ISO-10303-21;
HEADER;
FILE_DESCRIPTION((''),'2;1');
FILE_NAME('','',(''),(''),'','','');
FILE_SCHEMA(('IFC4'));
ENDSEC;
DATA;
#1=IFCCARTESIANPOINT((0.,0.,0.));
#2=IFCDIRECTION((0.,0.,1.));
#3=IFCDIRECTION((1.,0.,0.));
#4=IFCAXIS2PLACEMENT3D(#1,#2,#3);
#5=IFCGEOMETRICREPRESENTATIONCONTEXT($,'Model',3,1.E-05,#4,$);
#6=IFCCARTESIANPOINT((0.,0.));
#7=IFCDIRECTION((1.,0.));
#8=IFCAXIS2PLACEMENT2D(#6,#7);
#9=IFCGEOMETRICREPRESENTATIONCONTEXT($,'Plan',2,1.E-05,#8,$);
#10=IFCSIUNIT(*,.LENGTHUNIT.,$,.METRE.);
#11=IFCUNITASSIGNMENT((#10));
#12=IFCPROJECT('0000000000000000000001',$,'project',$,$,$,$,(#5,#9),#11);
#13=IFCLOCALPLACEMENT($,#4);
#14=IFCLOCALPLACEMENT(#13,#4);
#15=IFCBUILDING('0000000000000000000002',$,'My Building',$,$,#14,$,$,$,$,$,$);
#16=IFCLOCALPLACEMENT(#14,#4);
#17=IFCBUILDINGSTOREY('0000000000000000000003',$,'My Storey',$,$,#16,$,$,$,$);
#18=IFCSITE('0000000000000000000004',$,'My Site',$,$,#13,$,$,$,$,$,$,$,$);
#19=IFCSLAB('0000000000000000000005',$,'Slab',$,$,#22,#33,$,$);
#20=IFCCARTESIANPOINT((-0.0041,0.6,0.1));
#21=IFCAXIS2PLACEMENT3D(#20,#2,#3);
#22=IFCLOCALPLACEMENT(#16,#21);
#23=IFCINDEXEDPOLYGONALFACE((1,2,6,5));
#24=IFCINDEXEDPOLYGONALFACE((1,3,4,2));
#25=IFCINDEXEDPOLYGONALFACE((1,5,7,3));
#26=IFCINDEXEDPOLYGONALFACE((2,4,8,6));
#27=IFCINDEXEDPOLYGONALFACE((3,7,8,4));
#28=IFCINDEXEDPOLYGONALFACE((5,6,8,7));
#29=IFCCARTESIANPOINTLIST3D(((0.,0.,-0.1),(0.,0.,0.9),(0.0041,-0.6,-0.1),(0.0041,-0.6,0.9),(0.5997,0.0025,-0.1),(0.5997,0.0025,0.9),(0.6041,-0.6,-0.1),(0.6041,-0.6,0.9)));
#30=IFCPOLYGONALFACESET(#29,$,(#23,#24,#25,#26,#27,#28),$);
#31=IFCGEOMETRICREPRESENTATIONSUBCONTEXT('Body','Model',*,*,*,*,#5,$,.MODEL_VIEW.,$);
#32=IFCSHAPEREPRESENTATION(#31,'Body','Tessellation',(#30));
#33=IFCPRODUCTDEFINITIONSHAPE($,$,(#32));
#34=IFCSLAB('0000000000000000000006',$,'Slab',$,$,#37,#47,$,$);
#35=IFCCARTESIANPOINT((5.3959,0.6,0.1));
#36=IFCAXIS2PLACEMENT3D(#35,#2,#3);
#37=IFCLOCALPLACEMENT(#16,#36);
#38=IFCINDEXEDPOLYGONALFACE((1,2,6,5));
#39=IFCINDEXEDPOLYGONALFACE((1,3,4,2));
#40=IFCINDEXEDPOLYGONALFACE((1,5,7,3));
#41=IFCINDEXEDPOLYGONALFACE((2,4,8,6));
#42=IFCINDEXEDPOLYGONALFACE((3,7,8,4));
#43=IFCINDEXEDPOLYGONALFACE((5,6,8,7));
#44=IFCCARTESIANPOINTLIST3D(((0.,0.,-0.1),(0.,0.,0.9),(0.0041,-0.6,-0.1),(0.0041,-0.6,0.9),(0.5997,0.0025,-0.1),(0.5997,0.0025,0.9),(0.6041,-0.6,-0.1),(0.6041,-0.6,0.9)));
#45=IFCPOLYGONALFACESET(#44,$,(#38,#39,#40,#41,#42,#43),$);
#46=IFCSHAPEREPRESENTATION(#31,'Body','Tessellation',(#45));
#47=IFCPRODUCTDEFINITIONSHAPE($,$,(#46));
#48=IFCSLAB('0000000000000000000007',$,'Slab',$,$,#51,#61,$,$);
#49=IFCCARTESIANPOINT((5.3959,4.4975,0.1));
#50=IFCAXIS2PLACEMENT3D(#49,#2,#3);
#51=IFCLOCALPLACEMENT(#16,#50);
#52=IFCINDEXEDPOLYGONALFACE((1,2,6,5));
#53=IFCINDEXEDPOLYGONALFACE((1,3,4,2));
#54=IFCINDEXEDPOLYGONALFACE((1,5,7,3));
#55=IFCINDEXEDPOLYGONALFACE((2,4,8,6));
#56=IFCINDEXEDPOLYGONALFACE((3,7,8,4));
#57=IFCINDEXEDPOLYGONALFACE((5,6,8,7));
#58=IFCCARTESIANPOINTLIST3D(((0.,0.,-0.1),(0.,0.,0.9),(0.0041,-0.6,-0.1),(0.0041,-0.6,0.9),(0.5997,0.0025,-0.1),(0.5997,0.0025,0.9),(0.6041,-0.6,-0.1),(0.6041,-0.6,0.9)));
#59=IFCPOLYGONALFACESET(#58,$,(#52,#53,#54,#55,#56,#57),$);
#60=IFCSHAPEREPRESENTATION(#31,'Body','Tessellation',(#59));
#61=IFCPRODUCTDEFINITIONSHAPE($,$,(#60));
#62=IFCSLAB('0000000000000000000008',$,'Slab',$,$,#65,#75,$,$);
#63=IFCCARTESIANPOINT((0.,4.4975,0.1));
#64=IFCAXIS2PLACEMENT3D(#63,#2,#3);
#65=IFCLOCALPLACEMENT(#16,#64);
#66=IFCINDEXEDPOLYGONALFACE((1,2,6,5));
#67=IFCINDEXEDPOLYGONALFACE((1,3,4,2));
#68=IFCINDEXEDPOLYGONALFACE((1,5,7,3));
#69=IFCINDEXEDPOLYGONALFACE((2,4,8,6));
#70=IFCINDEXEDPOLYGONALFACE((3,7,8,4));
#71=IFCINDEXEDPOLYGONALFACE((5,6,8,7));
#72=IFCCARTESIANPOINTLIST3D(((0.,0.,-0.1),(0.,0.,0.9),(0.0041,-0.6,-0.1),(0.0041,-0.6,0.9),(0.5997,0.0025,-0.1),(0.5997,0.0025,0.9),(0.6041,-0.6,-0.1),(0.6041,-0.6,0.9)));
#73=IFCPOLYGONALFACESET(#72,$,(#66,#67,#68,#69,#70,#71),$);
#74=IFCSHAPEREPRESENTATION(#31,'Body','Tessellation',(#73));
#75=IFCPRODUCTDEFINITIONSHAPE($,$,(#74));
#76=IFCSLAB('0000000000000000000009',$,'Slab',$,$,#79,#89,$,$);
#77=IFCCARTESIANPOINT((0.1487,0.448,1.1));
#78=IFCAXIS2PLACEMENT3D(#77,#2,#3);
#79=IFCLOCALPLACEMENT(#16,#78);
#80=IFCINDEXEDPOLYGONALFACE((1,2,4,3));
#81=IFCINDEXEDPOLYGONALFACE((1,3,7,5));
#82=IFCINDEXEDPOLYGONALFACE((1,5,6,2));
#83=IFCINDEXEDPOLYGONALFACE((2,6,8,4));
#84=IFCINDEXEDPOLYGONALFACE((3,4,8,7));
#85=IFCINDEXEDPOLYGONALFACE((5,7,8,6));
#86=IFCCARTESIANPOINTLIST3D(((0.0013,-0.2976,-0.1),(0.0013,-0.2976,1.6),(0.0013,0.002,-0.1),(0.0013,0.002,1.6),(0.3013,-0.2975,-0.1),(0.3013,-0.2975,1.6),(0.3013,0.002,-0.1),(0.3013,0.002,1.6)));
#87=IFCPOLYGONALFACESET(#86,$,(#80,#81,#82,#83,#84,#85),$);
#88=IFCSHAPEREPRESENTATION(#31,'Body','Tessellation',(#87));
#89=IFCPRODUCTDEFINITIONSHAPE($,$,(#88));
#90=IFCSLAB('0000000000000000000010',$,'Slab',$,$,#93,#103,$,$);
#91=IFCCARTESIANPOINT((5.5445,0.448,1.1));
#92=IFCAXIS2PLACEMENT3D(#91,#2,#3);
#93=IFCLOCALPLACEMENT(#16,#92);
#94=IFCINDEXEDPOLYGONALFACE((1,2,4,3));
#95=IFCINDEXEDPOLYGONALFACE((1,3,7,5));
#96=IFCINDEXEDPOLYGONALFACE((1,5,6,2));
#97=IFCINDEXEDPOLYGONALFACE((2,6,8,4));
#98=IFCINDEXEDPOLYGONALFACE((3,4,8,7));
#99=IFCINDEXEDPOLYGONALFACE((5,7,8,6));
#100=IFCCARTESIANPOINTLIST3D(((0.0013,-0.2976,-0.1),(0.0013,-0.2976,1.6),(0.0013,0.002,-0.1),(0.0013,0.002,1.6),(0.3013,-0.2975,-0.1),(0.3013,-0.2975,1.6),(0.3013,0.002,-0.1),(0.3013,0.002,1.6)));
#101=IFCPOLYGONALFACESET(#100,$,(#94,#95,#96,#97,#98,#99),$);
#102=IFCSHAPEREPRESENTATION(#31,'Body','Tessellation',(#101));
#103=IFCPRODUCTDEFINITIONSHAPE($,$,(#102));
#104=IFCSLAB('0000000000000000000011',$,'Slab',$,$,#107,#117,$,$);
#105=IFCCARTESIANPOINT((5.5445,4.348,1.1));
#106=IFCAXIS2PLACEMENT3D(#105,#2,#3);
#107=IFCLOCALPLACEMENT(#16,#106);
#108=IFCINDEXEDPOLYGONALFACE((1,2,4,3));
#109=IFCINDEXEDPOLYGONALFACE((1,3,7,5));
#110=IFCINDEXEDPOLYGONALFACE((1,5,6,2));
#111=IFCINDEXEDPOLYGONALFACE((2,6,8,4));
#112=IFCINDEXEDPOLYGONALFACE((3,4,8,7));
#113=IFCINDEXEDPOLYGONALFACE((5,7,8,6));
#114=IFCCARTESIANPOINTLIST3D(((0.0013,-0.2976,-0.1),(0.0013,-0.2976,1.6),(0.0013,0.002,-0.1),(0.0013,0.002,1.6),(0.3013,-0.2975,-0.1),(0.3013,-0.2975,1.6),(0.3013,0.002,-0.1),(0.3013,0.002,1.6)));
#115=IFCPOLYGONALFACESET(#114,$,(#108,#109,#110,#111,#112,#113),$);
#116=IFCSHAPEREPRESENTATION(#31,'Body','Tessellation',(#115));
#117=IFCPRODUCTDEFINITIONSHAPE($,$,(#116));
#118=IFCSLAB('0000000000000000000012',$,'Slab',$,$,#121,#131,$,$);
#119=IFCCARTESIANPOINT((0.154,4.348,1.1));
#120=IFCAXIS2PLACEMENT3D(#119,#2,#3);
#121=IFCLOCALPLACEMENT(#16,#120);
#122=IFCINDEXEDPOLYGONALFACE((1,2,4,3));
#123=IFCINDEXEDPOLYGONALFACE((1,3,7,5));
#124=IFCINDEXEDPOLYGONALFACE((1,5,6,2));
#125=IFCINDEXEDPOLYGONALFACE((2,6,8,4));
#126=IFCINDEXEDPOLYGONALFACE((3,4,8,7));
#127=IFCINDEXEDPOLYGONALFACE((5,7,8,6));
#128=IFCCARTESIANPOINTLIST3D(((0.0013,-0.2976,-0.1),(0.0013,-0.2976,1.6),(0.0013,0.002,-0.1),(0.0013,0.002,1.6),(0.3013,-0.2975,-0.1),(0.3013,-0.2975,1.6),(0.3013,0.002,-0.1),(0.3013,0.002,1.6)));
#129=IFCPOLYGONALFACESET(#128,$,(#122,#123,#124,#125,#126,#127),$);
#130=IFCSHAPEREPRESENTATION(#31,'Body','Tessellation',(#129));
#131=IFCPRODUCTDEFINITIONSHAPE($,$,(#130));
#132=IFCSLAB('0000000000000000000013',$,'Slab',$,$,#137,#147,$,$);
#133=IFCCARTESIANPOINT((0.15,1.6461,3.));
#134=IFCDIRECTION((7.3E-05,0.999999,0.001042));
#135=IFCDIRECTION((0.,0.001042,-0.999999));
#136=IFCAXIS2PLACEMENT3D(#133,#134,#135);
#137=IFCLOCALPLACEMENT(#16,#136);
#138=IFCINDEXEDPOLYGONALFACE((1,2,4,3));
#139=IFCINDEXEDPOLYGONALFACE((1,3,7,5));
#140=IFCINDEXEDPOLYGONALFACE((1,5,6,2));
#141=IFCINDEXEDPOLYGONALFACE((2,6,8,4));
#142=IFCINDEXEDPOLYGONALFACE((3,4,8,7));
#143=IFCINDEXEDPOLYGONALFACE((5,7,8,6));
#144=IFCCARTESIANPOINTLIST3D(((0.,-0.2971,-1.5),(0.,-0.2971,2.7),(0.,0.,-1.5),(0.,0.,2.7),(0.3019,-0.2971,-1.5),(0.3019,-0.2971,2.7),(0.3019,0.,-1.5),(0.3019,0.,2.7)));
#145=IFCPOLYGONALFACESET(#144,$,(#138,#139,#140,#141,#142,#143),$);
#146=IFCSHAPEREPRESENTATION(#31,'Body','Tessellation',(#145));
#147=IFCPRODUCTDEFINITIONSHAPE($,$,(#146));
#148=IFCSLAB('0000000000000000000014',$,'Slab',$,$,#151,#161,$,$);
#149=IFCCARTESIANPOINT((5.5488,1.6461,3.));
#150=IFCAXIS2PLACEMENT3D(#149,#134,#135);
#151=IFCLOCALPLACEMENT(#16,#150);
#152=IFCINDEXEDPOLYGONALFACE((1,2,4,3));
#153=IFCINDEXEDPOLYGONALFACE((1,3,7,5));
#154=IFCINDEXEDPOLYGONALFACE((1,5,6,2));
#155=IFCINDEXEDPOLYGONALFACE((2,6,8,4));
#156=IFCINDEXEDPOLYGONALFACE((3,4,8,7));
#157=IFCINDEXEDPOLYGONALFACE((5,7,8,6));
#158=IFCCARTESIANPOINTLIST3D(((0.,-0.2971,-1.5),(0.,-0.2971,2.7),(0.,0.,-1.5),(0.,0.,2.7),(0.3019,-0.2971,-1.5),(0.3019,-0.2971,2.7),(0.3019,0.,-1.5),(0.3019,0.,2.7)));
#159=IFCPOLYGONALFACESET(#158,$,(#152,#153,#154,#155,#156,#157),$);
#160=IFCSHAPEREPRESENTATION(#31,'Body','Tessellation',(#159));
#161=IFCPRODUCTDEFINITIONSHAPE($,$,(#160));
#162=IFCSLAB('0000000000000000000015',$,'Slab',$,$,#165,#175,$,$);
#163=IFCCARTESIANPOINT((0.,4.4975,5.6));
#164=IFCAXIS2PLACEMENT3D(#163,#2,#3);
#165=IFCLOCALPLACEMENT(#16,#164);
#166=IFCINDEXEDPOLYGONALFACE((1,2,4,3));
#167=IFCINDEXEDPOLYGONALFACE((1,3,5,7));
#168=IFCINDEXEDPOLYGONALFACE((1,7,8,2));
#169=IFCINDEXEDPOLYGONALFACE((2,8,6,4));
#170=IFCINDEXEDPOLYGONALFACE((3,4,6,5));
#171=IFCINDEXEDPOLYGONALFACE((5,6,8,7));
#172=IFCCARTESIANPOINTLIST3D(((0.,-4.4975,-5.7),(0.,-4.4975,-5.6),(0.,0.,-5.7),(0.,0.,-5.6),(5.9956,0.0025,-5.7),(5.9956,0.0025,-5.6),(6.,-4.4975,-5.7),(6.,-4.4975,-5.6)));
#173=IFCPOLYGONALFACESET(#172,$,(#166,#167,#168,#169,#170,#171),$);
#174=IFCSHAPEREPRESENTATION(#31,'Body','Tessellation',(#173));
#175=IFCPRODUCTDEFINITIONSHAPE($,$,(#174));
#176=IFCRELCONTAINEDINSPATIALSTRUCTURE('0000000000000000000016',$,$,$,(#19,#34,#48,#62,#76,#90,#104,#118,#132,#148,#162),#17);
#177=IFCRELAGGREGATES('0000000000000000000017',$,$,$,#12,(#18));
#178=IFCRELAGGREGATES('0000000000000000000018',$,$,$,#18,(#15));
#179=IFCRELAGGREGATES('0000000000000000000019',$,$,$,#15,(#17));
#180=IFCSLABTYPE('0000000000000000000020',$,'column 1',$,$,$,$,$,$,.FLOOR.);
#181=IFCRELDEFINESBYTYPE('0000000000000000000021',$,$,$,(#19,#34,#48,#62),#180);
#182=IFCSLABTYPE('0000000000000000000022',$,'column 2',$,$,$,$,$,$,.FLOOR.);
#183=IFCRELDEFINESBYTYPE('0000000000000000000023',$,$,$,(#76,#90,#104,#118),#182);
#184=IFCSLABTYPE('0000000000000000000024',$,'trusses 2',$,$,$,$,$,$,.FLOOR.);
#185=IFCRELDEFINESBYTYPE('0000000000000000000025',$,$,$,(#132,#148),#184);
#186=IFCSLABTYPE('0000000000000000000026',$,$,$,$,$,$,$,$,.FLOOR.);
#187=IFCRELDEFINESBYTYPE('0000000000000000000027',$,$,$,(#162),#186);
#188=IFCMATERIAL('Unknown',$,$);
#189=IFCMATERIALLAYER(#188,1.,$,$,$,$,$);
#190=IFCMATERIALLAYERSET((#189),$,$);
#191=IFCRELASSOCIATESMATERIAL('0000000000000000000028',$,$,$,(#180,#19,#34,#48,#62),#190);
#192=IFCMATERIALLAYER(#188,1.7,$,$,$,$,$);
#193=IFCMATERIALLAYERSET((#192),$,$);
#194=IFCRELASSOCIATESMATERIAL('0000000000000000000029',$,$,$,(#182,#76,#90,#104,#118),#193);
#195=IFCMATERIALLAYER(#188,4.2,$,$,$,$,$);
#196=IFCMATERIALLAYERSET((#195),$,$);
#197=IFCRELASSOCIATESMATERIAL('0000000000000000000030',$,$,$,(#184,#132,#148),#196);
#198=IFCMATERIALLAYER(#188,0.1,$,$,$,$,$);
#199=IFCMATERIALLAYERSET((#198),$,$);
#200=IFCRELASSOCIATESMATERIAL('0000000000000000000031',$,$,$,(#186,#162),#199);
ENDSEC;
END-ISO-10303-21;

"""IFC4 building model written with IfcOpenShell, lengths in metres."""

from ifc_helpers import new_model, si_unit, frame, origin_with_axes, origin_2d_with_axis, place, context, subcontext, project, spatial, indexed_curve, outline, extrude, material, layer, layer_set, layer_usage, type_object, element, save


model = new_model("IFC4")

# Units and contexts
model_context = context("Model", 3, precision=1e-05, world=origin_with_axes())
plan_context = context("Plan", 2, precision=1e-05, world=origin_2d_with_axis())
body_context_1 = subcontext(model_context, "Body", "Model", "MODEL_VIEW")
ifc_project = project(units=[si_unit("LENGTHUNIT", "METRE")], contexts=[model_context, plan_context])

# Site, building, storey
site_placement = place(None, origin_with_axes())
site = spatial("IfcSite", under=ifc_project, at=site_placement, Name="My Site")
building_placement = place(site_placement, origin_with_axes())
building = spatial("IfcBuilding", under=site, at=building_placement, Name="My Building")
storey_placement = place(building_placement, origin_with_axes())
storey = spatial("IfcBuildingStorey", under=building, at=storey_placement, Name="My Storey")

# Slabs
ifc_material = material(Name="Unknown")
ifc_layer_1 = layer(ifc_material, 1.0)
ifc_layer_set_1 = layer_set([ifc_layer_1])
ifc_layer_usage_1 = layer_usage(ifc_layer_set_1, "AXIS3", "POSITIVE", -0.1)
slab_type_1 = type_object("IfcSlabType", Name="column 1", PredefinedType="FLOOR", material=ifc_layer_set_1)
slab_1_placement = place(storey_placement, frame((-0.0041, 0.6, 0.1), z_axis=(0.0, 0.0, 1.0), x_axis=(1.0, 0.0, 0.0)))
element("IfcSlab", 1, at=slab_1_placement, inside=storey, type_object=slab_type_1, material=ifc_layer_usage_1, Name="Slab", context=body_context_1, shape_type="SweptSolid", body=[
    extrude(outline(indexed_curve([(0.0, 0.0), (0.5997, 0.0025), (0.6041, -0.6), (0.0041, -0.6), (0.0, 0.0)])), frame((0.0, 0.0, -0.1), z_axis=(0.0, 0.0, 1.0), x_axis=(1.0, 0.0, 0.0)), (0.0, 0.0, 1.0), 1.0),
])
ifc_layer_usage_2 = layer_usage(ifc_layer_set_1, "AXIS3", "POSITIVE", -0.1)
slab_2_placement = place(storey_placement, frame((5.3959, 0.6, 0.1), z_axis=(0.0, 0.0, 1.0), x_axis=(1.0, 0.0, 0.0)))
element("IfcSlab", 2, at=slab_2_placement, inside=storey, type_object=slab_type_1, material=ifc_layer_usage_2, Name="Slab", context=body_context_1, shape_type="SweptSolid", body=[
    extrude(outline(indexed_curve([(0.0, 0.0), (0.5997, 0.0025), (0.6041, -0.6), (0.0041, -0.6), (0.0, 0.0)])), frame((0.0, 0.0, -0.1), z_axis=(0.0, 0.0, 1.0), x_axis=(1.0, 0.0, 0.0)), (0.0, 0.0, 1.0), 1.0),
])
ifc_layer_usage_3 = layer_usage(ifc_layer_set_1, "AXIS3", "POSITIVE", -0.1)
slab_3_placement = place(storey_placement, frame((5.3959, 4.4975, 0.1), z_axis=(0.0, 0.0, 1.0), x_axis=(1.0, 0.0, 0.0)))
element("IfcSlab", 3, at=slab_3_placement, inside=storey, type_object=slab_type_1, material=ifc_layer_usage_3, Name="Slab", context=body_context_1, shape_type="SweptSolid", body=[
    extrude(outline(indexed_curve([(0.0, 0.0), (0.5997, 0.0025), (0.6041, -0.6), (0.0041, -0.6), (0.0, 0.0)])), frame((0.0, 0.0, -0.1), z_axis=(0.0, 0.0, 1.0), x_axis=(1.0, 0.0, 0.0)), (0.0, 0.0, 1.0), 1.0),
])
ifc_layer_usage_4 = layer_usage(ifc_layer_set_1, "AXIS3", "POSITIVE", -0.1)
slab_4_placement = place(storey_placement, frame((0.0, 4.4975, 0.1), z_axis=(0.0, 0.0, 1.0), x_axis=(1.0, 0.0, 0.0)))
element("IfcSlab", 4, at=slab_4_placement, inside=storey, type_object=slab_type_1, material=ifc_layer_usage_4, Name="Slab", context=body_context_1, shape_type="SweptSolid", body=[
    extrude(outline(indexed_curve([(0.0, 0.0), (0.5997, 0.0025), (0.6041, -0.6), (0.0041, -0.6), (0.0, 0.0)])), frame((0.0, 0.0, -0.1), z_axis=(0.0, 0.0, 1.0), x_axis=(1.0, 0.0, 0.0)), (0.0, 0.0, 1.0), 1.0),
])
ifc_layer_2 = layer(ifc_material, 1.7)
ifc_layer_set_2 = layer_set([ifc_layer_2])
ifc_layer_usage_5 = layer_usage(ifc_layer_set_2, "AXIS3", "POSITIVE", -0.1)
slab_type_2 = type_object("IfcSlabType", Name="column 2", PredefinedType="FLOOR", material=ifc_layer_set_2)
slab_5_placement = place(storey_placement, frame((0.1487, 0.448, 1.1), z_axis=(0.0, 0.0, 1.0), x_axis=(1.0, 0.0, 0.0)))
element("IfcSlab", 5, at=slab_5_placement, inside=storey, type_object=slab_type_2, material=ifc_layer_usage_5, Name="Slab", context=body_context_1, shape_type="SweptSolid", body=[
    extrude(outline(indexed_curve([(0.3013, 0.002), (0.3013, -0.2975), (0.0013, -0.2976), (0.0013, 0.002), (0.3013, 0.002)])), frame((0.0, 0.0, -0.1), z_axis=(0.0, 0.0, 1.0), x_axis=(1.0, 0.0, 0.0)), (0.0, 0.0, 1.0), 1.7),
])
ifc_layer_usage_6 = layer_usage(ifc_layer_set_2, "AXIS3", "POSITIVE", -0.1)
slab_6_placement = place(storey_placement, frame((5.5445, 0.448, 1.1), z_axis=(0.0, 0.0, 1.0), x_axis=(1.0, 0.0, 0.0)))
element("IfcSlab", 6, at=slab_6_placement, inside=storey, type_object=slab_type_2, material=ifc_layer_usage_6, Name="Slab", context=body_context_1, shape_type="SweptSolid", body=[
    extrude(outline(indexed_curve([(0.3013, 0.002), (0.3013, -0.2975), (0.0013, -0.2976), (0.0013, 0.002), (0.3013, 0.002)])), frame((0.0, 0.0, -0.1), z_axis=(0.0, 0.0, 1.0), x_axis=(1.0, 0.0, 0.0)), (0.0, 0.0, 1.0), 1.7),
])
ifc_layer_usage_7 = layer_usage(ifc_layer_set_2, "AXIS3", "POSITIVE", -0.1)
slab_7_placement = place(storey_placement, frame((5.5445, 4.348, 1.1), z_axis=(0.0, 0.0, 1.0), x_axis=(1.0, 0.0, 0.0)))
element("IfcSlab", 7, at=slab_7_placement, inside=storey, type_object=slab_type_2, material=ifc_layer_usage_7, Name="Slab", context=body_context_1, shape_type="SweptSolid", body=[
    extrude(outline(indexed_curve([(0.3013, 0.002), (0.3013, -0.2975), (0.0013, -0.2976), (0.0013, 0.002), (0.3013, 0.002)])), frame((0.0, 0.0, -0.1), z_axis=(0.0, 0.0, 1.0), x_axis=(1.0, 0.0, 0.0)), (0.0, 0.0, 1.0), 1.7),
])
ifc_layer_usage_8 = layer_usage(ifc_layer_set_2, "AXIS3", "POSITIVE", -0.1)
slab_8_placement = place(storey_placement, frame((0.154, 4.348, 1.1), z_axis=(0.0, 0.0, 1.0), x_axis=(1.0, 0.0, 0.0)))
element("IfcSlab", 8, at=slab_8_placement, inside=storey, type_object=slab_type_2, material=ifc_layer_usage_8, Name="Slab", context=body_context_1, shape_type="SweptSolid", body=[
    extrude(outline(indexed_curve([(0.3013, 0.002), (0.3013, -0.2975), (0.0013, -0.2976), (0.0013, 0.002), (0.3013, 0.002)])), frame((0.0, 0.0, -0.1), z_axis=(0.0, 0.0, 1.0), x_axis=(1.0, 0.0, 0.0)), (0.0, 0.0, 1.0), 1.7),
])
ifc_layer_3 = layer(ifc_material, 4.2)
ifc_layer_set_3 = layer_set([ifc_layer_3])
ifc_layer_usage_9 = layer_usage(ifc_layer_set_3, "AXIS3", "POSITIVE", -1.5)
slab_type_3 = type_object("IfcSlabType", Name="trusses 2", PredefinedType="FLOOR", material=ifc_layer_set_3)
slab_9_placement = place(storey_placement, frame((0.15, 1.6461, 3.0), z_axis=(0.000073, 0.999999, 0.001042), x_axis=(0.0, 0.001042, -0.999999)))
element("IfcSlab", 9, at=slab_9_placement, inside=storey, type_object=slab_type_3, material=ifc_layer_usage_9, Name="Slab", context=body_context_1, shape_type="SweptSolid", body=[
    extrude(outline(indexed_curve([(0.0, 0.0), (0.3019, 0.0), (0.3019, -0.2971), (0.0, -0.2971), (0.0, 0.0)])), frame((0.0, 0.0, -1.5), z_axis=(0.0, 0.0, 1.0), x_axis=(1.0, 0.0, 0.0)), (0.0, 0.0, 1.0), 4.2),
])
ifc_layer_usage_10 = layer_usage(ifc_layer_set_3, "AXIS3", "POSITIVE", -1.5)
slab_10_placement = place(storey_placement, frame((5.5488, 1.6461, 3.0), z_axis=(0.000073, 0.999999, 0.001042), x_axis=(0.0, 0.001042, -0.999999)))
element("IfcSlab", 10, at=slab_10_placement, inside=storey, type_object=slab_type_3, material=ifc_layer_usage_10, Name="Slab", context=body_context_1, shape_type="SweptSolid", body=[
    extrude(outline(indexed_curve([(0.0, 0.0), (0.3019, 0.0), (0.3019, -0.2971), (0.0, -0.2971), (0.0, 0.0)])), frame((0.0, 0.0, -1.5), z_axis=(0.0, 0.0, 1.0), x_axis=(1.0, 0.0, 0.0)), (0.0, 0.0, 1.0), 4.2),
])
ifc_layer_4 = layer(ifc_material, 0.1)
ifc_layer_set_4 = layer_set([ifc_layer_4])
ifc_layer_usage_11 = layer_usage(ifc_layer_set_4, "AXIS3", "POSITIVE", -5.7)
slab_type_4 = type_object("IfcSlabType", PredefinedType="FLOOR", material=ifc_layer_set_4)
slab_11_placement = place(storey_placement, frame((0.0, 4.4975, 5.6), z_axis=(0.0, 0.0, 1.0), x_axis=(1.0, 0.0, 0.0)))
element("IfcSlab", 11, at=slab_11_placement, inside=storey, type_object=slab_type_4, material=ifc_layer_usage_11, Name="Slab", context=body_context_1, shape_type="SweptSolid", body=[
    extrude(outline(indexed_curve([(0.0, 0.0), (5.9956, 0.0025), (6.0, -4.4975), (0.0, -4.4975), (0.0, 0.0)])), frame((0.0, 0.0, -5.7), z_axis=(0.0, 0.0, 1.0), x_axis=(1.0, 0.0, 0.0)), (0.0, 0.0, 1.0), 0.1),
])

save(model, "model.ifc")
